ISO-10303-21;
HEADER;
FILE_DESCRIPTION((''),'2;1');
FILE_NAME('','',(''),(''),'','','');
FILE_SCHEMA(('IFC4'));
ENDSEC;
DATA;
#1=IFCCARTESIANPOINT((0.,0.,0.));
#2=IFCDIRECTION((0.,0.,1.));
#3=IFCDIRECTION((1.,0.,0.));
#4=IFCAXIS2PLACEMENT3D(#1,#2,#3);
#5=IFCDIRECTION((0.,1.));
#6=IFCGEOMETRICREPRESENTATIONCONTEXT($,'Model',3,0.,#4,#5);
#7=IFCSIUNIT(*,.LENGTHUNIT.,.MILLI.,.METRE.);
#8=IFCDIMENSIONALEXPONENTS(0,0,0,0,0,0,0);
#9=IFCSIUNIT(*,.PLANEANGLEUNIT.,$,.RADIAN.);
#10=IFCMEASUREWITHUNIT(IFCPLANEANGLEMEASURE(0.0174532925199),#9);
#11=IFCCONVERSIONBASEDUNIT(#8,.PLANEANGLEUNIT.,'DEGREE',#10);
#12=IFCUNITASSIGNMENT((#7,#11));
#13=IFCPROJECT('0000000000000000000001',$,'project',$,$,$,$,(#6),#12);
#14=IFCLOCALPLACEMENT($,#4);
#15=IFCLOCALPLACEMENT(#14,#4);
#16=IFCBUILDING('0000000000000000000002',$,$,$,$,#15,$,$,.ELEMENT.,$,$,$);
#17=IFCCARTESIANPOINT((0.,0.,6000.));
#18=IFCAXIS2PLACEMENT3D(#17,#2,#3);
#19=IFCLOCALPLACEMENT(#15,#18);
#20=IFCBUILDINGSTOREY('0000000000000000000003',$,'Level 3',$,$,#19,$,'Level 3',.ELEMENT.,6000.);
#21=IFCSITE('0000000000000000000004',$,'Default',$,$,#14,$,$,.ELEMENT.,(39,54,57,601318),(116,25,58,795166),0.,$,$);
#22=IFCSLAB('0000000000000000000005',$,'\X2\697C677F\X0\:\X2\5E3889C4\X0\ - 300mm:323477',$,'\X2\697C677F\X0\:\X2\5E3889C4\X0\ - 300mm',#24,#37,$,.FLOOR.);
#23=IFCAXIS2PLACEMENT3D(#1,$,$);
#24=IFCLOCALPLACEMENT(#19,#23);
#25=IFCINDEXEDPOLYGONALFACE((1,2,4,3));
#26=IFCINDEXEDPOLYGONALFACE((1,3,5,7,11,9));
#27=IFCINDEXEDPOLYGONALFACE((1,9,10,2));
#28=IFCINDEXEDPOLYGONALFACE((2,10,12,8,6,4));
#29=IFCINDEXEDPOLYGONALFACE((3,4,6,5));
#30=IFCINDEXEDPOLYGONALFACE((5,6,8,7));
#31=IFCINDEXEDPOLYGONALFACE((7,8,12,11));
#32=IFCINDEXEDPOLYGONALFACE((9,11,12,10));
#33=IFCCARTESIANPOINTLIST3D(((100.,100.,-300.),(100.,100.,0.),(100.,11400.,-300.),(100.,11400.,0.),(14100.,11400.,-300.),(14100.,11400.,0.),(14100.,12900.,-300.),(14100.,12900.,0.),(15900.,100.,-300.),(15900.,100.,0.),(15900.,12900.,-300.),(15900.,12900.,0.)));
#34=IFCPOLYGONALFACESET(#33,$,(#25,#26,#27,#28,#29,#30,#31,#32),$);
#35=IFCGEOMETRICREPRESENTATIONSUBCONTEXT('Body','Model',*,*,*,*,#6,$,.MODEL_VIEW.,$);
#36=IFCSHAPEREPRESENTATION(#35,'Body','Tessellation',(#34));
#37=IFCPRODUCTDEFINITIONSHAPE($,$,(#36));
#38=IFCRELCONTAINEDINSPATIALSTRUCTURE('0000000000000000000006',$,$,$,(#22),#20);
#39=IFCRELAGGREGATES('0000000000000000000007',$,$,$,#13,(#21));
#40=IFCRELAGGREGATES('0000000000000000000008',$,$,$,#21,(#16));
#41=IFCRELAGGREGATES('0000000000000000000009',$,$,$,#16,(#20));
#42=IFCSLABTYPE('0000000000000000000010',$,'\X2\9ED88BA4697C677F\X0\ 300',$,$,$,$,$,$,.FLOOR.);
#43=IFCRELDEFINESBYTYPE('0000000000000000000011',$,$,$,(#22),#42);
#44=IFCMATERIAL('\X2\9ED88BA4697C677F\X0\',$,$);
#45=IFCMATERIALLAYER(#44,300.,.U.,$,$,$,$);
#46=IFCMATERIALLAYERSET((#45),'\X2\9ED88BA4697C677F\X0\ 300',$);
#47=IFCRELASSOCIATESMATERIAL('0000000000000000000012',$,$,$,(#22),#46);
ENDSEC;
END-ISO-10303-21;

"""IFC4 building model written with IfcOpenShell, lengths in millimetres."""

from ifc_helpers import new_model, entity, si_unit, converted_unit, direction, frame, origin_with_axes, place, context, subcontext, project, spatial, polyline, outline, extrude, material, layer, layer_set, layer_usage, type_object, element, save


model = new_model("IFC4")

# Units and contexts
model_context = context("Model", 3, precision=0.0, world=origin_with_axes(), true_north=direction((0.0, 1.0)))
body_context = subcontext(model_context, "Body", "Model", "MODEL_VIEW")
ifc_project = project(units=[si_unit("LENGTHUNIT", "METRE", prefix="MILLI"), converted_unit("PLANEANGLEUNIT", "DEGREE", entity("IfcPlaneAngleMeasure", 0.0174532925199), si_unit("PLANEANGLEUNIT", "RADIAN"), dimensions=[0, 0, 0, 0, 0, 0, 0])], contexts=[model_context])

# Site, building, storey
site_placement = place(None, origin_with_axes())
site = spatial("IfcSite", under=ifc_project, at=site_placement, Name="Default", CompositionType="ELEMENT", RefLatitude=(39, 54, 57, 601318), RefLongitude=(116, 25, 58, 795166), RefElevation=0.0)
building_placement = place(site_placement, origin_with_axes())
building = spatial("IfcBuilding", under=site, at=building_placement, CompositionType="ELEMENT")
storey_placement = place(building_placement, frame((0.0, 0.0, 6000.0), z_axis=(0.0, 0.0, 1.0), x_axis=(1.0, 0.0, 0.0)))
storey = spatial("IfcBuildingStorey", under=building, at=storey_placement, Name="Level 3", LongName="Level 3", CompositionType="ELEMENT", Elevation=6000.0)

# Slab
ifc_material = material(Name="默认楼板")
ifc_layer = layer(ifc_material, 300.0, ventilated="UNKNOWN")
ifc_layer_set = layer_set([ifc_layer], Name="默认楼板 300")
ifc_layer_usage = layer_usage(ifc_layer_set, "AXIS3", "NEGATIVE", 300.0)
slab_type = type_object("IfcSlabType", Name="默认楼板 300", PredefinedType="FLOOR")
slab_placement = place(storey_placement, frame((100.0, 100.0, 0.0), z_axis=(0.0, 0.0, 1.0), x_axis=(1.0, 0.0, 0.0)))
element("IfcSlab", 1, at=slab_placement, inside=storey, type_object=slab_type, material=ifc_layer_usage, Name="楼板:常规 - 300mm:323477", ObjectType="楼板:常规 - 300mm", PredefinedType="FLOOR", context=body_context, shape_type="SweptSolid", body=[
    extrude(outline(polyline([(0.0, 0.0), (15800.0, 0.0), (15800.0, 12800.0), (14000.0, 12800.0), (14000.0, 11300.0), (0.0, 11300.0), (0.0, 0.0)])), frame((0.0, 0.0, -300.0), z_axis=(0.0, 0.0, 1.0), x_axis=(1.0, 0.0, 0.0)), (0.0, 0.0, 1.0), 300.0),
])

save(model, "model.ifc")
